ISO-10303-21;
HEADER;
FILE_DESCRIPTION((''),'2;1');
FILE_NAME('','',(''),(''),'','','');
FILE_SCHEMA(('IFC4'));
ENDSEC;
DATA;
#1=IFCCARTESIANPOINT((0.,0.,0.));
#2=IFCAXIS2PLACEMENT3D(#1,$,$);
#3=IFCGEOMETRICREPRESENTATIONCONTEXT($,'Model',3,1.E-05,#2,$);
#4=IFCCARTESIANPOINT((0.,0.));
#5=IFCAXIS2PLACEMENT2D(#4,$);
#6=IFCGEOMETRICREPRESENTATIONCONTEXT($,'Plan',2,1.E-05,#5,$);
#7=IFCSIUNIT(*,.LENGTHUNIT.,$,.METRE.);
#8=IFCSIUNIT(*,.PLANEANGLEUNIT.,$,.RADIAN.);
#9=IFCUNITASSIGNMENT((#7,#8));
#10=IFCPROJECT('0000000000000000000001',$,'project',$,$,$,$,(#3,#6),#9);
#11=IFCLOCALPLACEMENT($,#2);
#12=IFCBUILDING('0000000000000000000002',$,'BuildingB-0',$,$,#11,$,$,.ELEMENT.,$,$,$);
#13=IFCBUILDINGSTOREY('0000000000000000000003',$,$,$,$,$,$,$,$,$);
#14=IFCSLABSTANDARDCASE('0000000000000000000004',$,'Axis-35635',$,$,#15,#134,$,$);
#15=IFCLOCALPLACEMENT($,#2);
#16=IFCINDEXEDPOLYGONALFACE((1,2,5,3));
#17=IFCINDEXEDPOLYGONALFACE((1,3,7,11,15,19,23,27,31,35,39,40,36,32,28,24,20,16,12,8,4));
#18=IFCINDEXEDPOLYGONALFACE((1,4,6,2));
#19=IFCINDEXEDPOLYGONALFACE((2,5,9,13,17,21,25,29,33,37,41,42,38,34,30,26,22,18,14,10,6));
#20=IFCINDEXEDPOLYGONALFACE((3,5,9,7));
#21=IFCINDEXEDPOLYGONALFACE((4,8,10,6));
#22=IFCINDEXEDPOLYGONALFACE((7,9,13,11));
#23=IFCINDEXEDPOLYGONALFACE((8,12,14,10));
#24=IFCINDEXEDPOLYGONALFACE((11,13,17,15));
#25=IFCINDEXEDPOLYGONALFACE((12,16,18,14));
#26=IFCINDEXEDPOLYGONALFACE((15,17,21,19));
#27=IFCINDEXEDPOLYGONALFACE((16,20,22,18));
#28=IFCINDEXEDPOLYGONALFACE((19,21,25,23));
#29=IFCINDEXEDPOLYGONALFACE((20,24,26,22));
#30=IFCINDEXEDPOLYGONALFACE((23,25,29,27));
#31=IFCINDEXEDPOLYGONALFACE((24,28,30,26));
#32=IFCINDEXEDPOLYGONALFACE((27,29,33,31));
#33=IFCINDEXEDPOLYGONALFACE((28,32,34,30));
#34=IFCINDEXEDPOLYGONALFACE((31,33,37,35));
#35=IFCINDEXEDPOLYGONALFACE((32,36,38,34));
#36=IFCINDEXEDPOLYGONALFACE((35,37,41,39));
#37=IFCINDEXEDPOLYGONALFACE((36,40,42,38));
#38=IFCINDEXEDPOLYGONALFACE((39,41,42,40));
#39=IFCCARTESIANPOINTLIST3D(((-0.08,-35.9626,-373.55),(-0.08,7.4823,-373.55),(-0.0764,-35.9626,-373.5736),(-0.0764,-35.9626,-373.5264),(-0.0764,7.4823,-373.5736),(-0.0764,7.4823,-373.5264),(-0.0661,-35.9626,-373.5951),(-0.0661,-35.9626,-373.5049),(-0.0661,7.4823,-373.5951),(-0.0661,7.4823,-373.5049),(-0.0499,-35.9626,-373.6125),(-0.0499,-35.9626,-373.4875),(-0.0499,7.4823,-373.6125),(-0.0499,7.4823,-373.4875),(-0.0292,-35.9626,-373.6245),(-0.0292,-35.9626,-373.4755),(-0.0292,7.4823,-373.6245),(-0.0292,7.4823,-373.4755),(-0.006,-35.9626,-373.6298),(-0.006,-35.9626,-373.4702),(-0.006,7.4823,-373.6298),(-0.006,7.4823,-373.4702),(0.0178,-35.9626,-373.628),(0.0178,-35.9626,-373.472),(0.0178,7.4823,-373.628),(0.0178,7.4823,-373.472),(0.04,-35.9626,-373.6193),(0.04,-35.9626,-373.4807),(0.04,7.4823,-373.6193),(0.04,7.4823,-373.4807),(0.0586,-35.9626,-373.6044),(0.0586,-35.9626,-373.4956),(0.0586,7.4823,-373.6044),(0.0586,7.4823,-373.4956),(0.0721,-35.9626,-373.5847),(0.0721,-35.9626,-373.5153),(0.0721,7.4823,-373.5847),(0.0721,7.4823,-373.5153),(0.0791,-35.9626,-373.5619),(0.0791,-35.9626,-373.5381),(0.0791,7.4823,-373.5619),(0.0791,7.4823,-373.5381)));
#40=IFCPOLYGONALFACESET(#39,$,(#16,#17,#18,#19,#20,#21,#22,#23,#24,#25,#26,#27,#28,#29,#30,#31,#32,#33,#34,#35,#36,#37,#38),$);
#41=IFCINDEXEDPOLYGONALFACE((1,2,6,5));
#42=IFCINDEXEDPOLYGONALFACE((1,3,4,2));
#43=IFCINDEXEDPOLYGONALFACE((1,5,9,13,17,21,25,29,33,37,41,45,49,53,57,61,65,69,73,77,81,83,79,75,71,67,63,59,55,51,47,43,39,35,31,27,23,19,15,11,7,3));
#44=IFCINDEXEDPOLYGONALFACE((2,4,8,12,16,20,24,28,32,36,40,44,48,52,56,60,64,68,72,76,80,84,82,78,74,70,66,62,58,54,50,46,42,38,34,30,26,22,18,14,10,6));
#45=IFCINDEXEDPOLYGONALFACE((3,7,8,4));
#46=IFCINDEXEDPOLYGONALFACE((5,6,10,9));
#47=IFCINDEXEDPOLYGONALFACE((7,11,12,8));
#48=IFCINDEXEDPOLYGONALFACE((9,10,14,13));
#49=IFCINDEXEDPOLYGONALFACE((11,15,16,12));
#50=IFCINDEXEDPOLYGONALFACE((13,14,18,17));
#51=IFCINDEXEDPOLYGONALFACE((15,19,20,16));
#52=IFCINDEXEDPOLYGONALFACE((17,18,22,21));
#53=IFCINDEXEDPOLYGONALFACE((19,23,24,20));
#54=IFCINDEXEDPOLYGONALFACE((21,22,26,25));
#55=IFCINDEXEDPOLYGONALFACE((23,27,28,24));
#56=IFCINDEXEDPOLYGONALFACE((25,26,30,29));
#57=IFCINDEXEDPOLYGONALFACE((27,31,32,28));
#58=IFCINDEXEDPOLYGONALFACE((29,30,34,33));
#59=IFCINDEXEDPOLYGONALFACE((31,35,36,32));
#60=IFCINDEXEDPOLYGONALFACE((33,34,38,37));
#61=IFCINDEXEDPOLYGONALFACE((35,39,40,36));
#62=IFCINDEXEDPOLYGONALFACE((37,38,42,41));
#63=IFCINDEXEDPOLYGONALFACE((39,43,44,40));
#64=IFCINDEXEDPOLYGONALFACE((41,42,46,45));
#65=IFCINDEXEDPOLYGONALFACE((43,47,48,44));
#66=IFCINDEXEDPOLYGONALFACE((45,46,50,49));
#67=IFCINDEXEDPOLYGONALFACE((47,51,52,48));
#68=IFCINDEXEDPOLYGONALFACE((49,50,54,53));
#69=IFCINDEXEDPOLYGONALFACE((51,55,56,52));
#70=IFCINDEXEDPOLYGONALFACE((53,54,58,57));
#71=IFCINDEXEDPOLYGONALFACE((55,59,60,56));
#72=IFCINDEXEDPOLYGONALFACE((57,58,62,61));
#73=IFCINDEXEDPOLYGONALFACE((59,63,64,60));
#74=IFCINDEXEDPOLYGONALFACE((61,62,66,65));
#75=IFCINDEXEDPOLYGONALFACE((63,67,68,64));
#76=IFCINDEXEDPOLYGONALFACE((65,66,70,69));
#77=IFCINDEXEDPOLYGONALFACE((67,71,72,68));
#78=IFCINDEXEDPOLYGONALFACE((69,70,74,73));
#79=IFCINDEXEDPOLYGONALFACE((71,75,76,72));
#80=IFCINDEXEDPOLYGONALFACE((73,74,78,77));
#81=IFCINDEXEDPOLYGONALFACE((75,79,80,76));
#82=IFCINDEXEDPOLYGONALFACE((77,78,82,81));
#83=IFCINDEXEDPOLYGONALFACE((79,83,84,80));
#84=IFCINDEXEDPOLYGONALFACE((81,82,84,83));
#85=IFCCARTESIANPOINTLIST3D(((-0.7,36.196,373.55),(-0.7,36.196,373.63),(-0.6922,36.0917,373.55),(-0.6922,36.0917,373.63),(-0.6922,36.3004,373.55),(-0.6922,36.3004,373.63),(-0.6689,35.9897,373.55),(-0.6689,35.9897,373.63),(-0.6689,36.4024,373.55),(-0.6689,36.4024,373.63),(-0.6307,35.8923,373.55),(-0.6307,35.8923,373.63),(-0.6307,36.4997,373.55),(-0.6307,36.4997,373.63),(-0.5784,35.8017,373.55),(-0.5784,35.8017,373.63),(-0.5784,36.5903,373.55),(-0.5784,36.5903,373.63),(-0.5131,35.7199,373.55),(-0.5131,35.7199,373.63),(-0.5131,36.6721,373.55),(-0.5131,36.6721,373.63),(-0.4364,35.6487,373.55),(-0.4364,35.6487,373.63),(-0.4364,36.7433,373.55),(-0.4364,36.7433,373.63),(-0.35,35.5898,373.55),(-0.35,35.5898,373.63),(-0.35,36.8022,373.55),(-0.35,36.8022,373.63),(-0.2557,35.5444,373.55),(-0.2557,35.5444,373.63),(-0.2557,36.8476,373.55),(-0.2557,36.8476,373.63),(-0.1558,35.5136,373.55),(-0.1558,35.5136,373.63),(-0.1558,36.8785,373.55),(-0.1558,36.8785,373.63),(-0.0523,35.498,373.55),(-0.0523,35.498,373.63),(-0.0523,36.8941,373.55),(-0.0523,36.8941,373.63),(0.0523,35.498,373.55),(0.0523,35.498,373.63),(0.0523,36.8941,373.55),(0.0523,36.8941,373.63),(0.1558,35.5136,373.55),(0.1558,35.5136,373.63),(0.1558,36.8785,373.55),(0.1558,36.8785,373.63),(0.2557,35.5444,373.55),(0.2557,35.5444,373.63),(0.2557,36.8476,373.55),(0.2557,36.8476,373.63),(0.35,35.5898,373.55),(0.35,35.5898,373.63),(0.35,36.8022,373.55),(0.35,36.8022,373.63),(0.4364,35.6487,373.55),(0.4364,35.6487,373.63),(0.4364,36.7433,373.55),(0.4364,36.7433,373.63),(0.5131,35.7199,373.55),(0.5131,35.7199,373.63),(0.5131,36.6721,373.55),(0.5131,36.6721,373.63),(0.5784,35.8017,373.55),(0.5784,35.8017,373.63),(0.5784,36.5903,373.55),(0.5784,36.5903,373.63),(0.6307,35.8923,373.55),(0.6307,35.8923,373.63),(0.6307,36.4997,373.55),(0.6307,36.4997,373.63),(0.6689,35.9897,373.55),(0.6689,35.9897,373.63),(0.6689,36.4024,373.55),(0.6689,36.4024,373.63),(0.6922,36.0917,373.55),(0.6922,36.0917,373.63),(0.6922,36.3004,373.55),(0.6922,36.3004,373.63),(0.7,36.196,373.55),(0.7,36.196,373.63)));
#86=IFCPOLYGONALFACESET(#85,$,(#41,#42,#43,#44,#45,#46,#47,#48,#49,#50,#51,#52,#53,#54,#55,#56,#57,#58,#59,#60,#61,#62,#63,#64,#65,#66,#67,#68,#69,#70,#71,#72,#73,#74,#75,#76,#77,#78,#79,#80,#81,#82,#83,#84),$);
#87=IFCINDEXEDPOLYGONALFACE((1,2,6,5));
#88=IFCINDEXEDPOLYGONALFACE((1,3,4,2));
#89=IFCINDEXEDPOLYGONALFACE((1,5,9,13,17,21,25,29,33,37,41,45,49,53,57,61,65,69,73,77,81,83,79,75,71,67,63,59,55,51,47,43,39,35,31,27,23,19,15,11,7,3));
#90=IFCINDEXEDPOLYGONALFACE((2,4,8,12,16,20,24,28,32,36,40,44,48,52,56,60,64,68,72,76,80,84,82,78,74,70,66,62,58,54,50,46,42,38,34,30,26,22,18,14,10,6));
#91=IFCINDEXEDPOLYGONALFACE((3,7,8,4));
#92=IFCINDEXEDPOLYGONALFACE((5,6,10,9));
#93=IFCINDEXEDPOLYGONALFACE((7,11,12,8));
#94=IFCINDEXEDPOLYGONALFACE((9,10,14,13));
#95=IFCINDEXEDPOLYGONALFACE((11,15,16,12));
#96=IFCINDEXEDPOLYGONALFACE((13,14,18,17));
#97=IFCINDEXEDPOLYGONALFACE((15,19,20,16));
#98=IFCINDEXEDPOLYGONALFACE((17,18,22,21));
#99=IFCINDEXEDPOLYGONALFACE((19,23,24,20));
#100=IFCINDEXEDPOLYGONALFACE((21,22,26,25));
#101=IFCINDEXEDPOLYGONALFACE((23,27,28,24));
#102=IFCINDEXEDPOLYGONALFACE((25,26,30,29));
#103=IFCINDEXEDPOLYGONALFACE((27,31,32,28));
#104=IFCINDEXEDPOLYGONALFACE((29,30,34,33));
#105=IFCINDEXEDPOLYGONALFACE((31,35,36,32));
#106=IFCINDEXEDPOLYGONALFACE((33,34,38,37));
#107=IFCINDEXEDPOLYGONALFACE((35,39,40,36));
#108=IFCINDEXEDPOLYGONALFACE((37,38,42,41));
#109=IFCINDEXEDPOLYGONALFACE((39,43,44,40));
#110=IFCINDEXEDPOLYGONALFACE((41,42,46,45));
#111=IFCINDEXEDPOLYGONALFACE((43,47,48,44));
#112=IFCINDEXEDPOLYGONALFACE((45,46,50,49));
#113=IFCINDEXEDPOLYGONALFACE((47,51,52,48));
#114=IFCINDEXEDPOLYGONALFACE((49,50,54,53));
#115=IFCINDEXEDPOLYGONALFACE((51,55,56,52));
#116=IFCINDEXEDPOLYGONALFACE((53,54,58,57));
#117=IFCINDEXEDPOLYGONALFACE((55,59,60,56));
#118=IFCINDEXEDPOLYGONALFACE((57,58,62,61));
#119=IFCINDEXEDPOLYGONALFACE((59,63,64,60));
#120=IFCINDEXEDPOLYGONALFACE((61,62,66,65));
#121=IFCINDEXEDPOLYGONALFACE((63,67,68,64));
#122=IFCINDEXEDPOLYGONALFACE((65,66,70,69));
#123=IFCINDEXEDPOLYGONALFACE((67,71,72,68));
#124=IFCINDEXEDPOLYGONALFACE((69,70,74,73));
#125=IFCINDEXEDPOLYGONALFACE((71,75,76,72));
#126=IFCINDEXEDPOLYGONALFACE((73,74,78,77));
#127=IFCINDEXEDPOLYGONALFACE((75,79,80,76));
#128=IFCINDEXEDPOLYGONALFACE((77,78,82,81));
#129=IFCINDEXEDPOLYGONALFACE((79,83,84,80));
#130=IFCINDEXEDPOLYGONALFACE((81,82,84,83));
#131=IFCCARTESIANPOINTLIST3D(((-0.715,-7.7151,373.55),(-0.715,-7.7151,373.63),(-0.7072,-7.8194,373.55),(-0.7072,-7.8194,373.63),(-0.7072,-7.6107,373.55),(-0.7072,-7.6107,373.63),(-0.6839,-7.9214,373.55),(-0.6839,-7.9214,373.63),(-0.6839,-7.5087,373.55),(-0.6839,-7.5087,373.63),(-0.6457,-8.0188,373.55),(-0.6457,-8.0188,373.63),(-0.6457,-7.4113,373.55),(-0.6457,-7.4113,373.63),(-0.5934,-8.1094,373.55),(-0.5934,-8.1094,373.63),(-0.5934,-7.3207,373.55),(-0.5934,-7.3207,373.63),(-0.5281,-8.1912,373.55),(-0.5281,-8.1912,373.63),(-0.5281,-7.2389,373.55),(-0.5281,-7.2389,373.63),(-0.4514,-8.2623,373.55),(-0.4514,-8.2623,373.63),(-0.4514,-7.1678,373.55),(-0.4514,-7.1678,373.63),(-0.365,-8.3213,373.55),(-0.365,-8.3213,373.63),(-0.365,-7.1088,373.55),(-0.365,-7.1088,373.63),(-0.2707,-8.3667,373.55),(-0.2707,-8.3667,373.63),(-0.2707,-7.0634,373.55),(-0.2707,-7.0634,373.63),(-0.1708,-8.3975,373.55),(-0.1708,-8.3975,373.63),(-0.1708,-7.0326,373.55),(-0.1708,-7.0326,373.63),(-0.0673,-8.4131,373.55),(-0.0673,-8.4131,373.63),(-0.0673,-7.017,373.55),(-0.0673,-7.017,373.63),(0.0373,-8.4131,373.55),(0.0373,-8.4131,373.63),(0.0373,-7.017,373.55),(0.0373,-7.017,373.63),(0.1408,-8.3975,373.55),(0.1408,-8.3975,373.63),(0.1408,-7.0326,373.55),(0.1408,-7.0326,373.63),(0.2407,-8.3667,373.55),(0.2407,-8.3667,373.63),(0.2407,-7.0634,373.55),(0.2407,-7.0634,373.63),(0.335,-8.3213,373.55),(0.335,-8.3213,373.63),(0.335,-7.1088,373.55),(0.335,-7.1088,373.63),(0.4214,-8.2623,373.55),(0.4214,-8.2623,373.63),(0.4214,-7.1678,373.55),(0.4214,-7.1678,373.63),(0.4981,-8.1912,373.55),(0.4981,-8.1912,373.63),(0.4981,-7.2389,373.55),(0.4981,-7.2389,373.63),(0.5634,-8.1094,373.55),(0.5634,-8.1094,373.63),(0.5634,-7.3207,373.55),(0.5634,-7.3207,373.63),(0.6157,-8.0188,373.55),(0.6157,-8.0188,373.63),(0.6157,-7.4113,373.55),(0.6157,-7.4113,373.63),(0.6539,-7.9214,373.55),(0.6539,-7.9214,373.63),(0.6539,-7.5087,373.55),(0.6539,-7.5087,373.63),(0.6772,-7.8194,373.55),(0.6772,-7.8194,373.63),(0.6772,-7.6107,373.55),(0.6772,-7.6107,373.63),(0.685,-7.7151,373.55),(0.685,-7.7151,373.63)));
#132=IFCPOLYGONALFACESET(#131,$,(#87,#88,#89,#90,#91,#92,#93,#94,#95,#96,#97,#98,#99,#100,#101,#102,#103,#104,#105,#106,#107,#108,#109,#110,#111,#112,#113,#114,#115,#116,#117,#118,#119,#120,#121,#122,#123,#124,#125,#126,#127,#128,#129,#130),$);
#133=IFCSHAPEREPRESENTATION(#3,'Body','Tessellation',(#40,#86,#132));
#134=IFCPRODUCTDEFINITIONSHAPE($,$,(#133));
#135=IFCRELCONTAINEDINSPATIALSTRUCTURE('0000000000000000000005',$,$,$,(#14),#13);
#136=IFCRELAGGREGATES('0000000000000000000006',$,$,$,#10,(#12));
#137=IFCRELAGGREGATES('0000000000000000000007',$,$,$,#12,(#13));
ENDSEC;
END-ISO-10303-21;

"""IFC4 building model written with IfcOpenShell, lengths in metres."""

from ifc_helpers import new_model, entity, si_unit, frame, origin, origin_2d, place, context, project, spatial, circle, extrude, element, save


model = new_model("IFC4")

# Units and contexts
model_context = context("Model", 3, precision=1e-05, world=origin())
plan_context = context("Plan", 2, precision=1e-05, world=origin_2d())
ifc_project = project(units=[si_unit("LENGTHUNIT", "METRE"), si_unit("PLANEANGLEUNIT", "RADIAN")], contexts=[model_context, plan_context])

# Building, storey
building_placement = place(None, origin())
building = spatial("IfcBuilding", under=ifc_project, at=building_placement, Name="BuildingB-0", CompositionType="ELEMENT")
storey = spatial("IfcBuildingStorey", under=building)

# Slab
element("IfcSlabStandardCase", 1, inside=storey, Name="Axis-35635", context=model_context, shape_type="AdvancedSweptSolid", body=[
    entity("IfcSurfaceCurveSweptAreaSolid", entity("IfcCircleProfileDef", "AREA", None, None, 0.08), None, entity("IfcPolyline", [entity("IfcCartesianPoint", [0.0, 35.9626, 373.55]), entity("IfcCartesianPoint", [0.0, -7.4823, 373.55])]), None, None, entity("IfcPlane", entity("IfcAxis2Placement3D", entity("IfcCartesianPoint", [0.0, 35.9626, 373.55]), entity("IfcDirection", [0.0, 0.0, 1.0]), entity("IfcDirection", [1.0, 0.0, 0.0])))),
    extrude(circle(Radius=0.7), frame((0.0, 36.196, 373.55)), (0.0, 0.0, 1.0), 0.08),
    extrude(circle(Radius=0.7), frame((-0.015, -7.7151, 373.55)), (0.0, 0.0, 1.0), 0.08),
])

save(model, "model.ifc")
